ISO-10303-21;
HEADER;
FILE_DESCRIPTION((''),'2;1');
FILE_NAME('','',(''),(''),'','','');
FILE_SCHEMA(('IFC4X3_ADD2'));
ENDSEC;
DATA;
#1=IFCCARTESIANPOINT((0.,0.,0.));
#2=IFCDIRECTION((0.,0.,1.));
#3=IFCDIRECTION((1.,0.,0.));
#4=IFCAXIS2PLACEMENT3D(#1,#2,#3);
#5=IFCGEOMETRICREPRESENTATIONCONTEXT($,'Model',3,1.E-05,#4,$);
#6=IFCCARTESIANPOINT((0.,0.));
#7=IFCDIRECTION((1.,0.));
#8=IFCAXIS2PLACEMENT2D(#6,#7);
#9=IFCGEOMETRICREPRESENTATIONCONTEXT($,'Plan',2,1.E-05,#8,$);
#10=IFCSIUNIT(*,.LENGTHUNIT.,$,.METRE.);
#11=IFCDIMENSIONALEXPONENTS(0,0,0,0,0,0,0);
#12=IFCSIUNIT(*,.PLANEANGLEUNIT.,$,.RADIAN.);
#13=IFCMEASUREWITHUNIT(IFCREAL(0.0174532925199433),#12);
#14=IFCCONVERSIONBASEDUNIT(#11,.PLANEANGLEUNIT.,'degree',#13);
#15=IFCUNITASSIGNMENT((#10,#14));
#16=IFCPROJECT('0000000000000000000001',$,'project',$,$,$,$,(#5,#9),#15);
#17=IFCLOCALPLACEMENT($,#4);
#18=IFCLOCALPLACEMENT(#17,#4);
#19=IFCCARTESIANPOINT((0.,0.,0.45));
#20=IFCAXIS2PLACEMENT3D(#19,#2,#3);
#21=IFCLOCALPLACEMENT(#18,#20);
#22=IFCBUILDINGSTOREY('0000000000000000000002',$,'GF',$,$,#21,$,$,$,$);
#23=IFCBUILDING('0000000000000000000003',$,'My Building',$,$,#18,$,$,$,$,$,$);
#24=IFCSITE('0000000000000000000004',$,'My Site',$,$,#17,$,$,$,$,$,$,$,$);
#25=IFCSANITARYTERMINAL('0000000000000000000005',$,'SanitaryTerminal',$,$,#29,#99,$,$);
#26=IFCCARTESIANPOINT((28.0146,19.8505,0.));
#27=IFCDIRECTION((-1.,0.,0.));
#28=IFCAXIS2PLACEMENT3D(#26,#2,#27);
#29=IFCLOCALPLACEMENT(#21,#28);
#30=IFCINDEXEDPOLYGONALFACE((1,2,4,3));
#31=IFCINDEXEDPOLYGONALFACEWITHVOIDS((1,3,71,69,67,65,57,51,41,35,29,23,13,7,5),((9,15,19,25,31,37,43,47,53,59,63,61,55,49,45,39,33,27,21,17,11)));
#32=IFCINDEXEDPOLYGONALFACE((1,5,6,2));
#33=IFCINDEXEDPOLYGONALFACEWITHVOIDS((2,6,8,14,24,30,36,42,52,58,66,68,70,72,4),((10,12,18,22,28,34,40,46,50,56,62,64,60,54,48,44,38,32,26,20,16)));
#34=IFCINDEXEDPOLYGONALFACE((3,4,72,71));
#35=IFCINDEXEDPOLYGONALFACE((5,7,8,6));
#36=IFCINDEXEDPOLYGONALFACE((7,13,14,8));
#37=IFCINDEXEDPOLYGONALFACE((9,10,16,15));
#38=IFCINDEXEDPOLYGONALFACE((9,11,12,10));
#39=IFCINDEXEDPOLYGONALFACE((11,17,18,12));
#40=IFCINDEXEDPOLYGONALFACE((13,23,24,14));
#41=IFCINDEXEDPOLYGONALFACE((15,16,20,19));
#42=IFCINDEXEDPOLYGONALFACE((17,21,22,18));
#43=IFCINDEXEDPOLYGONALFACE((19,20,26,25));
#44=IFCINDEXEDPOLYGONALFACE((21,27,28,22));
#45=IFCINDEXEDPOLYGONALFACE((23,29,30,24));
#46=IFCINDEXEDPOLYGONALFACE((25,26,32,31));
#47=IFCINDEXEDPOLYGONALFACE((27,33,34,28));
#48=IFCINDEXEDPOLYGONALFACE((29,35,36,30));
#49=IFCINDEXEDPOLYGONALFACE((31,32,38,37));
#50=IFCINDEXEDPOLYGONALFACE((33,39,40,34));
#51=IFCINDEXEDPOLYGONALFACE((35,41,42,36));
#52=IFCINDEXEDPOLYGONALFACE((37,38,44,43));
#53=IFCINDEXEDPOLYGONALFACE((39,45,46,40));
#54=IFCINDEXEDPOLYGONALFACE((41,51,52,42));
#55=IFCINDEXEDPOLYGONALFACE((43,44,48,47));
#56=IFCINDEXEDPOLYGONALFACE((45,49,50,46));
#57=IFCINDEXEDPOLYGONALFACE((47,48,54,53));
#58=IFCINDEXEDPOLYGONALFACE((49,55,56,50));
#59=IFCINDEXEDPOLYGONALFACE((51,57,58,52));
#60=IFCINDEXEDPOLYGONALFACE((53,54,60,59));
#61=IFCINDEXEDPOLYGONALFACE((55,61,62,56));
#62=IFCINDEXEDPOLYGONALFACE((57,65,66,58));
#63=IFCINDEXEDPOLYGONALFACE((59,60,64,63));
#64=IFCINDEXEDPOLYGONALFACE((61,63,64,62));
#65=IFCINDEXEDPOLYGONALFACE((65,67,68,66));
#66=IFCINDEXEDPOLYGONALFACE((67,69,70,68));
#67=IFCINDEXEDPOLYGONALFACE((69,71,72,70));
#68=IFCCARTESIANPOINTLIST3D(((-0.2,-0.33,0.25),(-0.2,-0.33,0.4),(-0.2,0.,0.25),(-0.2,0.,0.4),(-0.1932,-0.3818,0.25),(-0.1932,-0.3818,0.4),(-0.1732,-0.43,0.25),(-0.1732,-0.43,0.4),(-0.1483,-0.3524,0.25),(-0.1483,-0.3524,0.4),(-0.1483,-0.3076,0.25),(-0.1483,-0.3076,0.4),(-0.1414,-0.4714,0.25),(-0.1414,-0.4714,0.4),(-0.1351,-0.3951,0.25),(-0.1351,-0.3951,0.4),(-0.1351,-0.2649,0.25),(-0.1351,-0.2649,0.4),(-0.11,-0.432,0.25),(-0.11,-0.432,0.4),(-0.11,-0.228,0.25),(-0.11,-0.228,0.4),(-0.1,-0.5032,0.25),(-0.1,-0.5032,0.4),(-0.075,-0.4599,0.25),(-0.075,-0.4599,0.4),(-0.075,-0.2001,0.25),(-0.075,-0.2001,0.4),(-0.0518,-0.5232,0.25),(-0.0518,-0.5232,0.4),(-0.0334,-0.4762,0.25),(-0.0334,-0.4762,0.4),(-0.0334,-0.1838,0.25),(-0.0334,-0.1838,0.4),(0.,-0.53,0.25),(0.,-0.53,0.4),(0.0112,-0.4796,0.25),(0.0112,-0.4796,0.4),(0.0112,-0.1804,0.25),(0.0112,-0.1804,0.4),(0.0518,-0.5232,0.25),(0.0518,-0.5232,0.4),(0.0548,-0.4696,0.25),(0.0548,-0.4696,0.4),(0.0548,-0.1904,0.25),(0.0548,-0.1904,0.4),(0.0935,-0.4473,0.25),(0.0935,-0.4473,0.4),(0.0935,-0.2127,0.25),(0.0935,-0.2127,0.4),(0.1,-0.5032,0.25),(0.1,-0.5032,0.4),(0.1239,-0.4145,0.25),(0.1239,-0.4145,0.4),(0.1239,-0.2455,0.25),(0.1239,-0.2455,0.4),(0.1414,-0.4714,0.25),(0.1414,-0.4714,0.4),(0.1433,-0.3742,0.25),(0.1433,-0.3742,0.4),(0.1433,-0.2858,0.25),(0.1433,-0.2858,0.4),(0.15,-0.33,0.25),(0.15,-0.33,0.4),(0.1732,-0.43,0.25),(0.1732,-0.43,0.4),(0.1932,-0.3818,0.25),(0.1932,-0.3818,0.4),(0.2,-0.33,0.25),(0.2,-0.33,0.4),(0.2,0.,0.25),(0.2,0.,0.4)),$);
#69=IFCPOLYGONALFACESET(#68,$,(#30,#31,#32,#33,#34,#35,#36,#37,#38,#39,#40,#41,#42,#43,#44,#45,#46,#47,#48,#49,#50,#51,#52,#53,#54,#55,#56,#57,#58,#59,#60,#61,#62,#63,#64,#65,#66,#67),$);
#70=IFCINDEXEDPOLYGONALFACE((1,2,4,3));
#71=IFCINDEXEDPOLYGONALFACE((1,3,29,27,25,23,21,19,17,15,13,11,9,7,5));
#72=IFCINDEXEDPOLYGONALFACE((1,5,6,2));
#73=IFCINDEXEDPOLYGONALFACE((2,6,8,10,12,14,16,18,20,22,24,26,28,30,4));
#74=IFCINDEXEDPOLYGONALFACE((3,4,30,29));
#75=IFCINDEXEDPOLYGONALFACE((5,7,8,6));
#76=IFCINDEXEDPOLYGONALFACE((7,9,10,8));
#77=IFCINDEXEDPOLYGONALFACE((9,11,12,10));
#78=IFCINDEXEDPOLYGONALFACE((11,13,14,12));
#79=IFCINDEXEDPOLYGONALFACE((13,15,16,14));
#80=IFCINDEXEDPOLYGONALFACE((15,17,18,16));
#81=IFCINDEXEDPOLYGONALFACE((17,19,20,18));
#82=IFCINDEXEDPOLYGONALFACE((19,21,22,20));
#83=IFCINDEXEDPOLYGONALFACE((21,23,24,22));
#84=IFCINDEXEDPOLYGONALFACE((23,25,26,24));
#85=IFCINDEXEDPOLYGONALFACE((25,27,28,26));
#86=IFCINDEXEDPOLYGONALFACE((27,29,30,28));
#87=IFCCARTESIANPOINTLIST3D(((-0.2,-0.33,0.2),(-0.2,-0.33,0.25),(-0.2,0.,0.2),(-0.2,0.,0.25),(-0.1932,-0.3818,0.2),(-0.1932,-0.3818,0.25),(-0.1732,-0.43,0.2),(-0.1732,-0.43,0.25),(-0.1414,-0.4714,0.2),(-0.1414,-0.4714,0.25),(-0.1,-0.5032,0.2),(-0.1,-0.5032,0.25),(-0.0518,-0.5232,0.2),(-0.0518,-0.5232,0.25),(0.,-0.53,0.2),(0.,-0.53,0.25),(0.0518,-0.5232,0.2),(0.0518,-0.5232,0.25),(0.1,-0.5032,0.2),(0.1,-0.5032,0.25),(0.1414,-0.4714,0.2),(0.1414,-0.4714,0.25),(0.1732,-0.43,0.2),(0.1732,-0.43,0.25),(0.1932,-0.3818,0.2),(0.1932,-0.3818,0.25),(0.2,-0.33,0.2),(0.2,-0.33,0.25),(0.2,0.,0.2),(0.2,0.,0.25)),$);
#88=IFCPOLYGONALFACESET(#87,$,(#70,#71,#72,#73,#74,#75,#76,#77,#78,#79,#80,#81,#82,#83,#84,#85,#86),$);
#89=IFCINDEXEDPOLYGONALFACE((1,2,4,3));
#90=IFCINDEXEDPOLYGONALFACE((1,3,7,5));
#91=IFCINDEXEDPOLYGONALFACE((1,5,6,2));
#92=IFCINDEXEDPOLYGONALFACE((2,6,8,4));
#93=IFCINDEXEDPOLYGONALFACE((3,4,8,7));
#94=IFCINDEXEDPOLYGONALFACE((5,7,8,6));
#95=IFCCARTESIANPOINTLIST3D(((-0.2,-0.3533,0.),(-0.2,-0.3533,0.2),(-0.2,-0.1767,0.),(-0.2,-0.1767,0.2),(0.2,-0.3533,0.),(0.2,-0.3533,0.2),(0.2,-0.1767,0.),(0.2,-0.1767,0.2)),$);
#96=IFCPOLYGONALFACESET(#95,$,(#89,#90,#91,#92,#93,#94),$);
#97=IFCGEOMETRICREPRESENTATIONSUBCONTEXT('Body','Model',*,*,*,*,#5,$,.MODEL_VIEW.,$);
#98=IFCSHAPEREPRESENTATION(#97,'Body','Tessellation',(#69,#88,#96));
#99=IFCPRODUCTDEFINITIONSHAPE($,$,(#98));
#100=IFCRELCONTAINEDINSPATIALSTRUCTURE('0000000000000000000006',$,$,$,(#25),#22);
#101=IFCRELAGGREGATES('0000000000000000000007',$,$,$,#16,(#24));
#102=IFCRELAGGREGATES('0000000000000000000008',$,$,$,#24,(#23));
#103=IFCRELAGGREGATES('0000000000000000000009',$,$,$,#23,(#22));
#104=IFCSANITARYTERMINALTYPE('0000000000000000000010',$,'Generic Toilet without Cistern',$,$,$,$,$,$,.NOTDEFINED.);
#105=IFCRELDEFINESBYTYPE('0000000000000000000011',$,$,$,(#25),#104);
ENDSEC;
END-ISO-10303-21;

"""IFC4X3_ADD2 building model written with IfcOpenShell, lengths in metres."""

from ifc_helpers import new_model, entity, si_unit, converted_unit, frame, frame_2d, origin_with_axes, origin_2d_with_axis, place, context, subcontext, project, spatial, line, arc, indexed_curve, circle_curve, outline, extrude, shape, source, transform, mapped, type_object, type_shapes, element, save


model = new_model("IFC4X3_ADD2")

# Units and contexts
model_context = context("Model", 3, precision=1e-05, world=origin_with_axes())
plan_context = context("Plan", 2, precision=1e-05, world=origin_2d_with_axis())
body_context_1 = subcontext(model_context, "Body", "Model", "MODEL_VIEW")
body_context_2 = subcontext(plan_context, "Body", "Plan", "PLAN_VIEW")
ifc_project = project(units=[si_unit("LENGTHUNIT", "METRE"), converted_unit("PLANEANGLEUNIT", "degree", entity("IfcReal", 0.0174532925199433), si_unit("PLANEANGLEUNIT", "RADIAN"), dimensions=[0, 0, 0, 0, 0, 0, 0])], contexts=[model_context, plan_context])

# Site, building, storey
site_placement = place(None, origin_with_axes())
site = spatial("IfcSite", under=ifc_project, at=site_placement, Name="My Site")
building_placement = place(site_placement, origin_with_axes())
building = spatial("IfcBuilding", under=site, at=building_placement, Name="My Building")
storey_placement = place(building_placement, frame((0.0, 0.0, 0.45), z_axis=(0.0, 0.0, 1.0), x_axis=(1.0, 0.0, 0.0)))
storey = spatial("IfcBuildingStorey", under=building, at=storey_placement, Name="GF")

# Sanitary terminal
sanitary_terminal_type_1 = type_object("IfcSanitaryTerminalType", Name="Generic Toilet without Cistern", PredefinedType="NOTDEFINED")
shared_shape_1 = source(origin_with_axes(), body_context_1, "Body", "SweptSolid", [
    extrude(outline(indexed_curve([(-0.2, 0.0), (0.2, 0.0), (0.2, -0.33), (0.1414, -0.4714), (0.0, -0.53), (-0.1414, -0.4714), (-0.2, -0.33)], segments=[line(1, 2), line(2, 3), arc(3, 4, 5), arc(5, 6, 7), line(7, 1)]), holes=[circle_curve(frame_2d((0.0, -0.33)), 0.15)]), frame((0.0, 0.0, 0.25), z_axis=(0.0, 0.0, 1.0), x_axis=(1.0, 0.0, 0.0)), (0.0, 0.0, 1.0), 0.15),
    extrude(outline(indexed_curve([(-0.2, 0.0), (0.2, 0.0), (0.2, -0.33), (0.1414, -0.4714), (0.0, -0.53), (-0.1414, -0.4714), (-0.2, -0.33)], segments=[line(1, 2), line(2, 3), arc(3, 4, 5), arc(5, 6, 7), line(7, 1)])), frame((0.0, 0.0, 0.2), z_axis=(0.0, 0.0, 1.0), x_axis=(1.0, 0.0, 0.0)), (0.0, 0.0, 1.0), 0.05),
    extrude(outline(indexed_curve([(-0.2, -0.1767), (0.2, -0.1767), (0.2, -0.3533), (-0.2, -0.3533)], segments=[line(1, 2, 3, 4, 1)])), origin_with_axes(), (0.0, 0.0, 1.0), 0.2),
])
shared_shape_2 = source(origin_with_axes(), body_context_2, "Body", "Annotation2D", [
    entity("IfcGeometricCurveSet", [entity("IfcIndexedPolyCurve", entity("IfcCartesianPointList2D", [[-0.1068, -0.124], [-0.0957, -0.1129], [-0.0804, -0.1088], [0.0804, -0.1088], [0.0957, -0.1129], [0.1068, -0.124], [0.1109, -0.1393], [0.1109, -0.3476], [0.1025, -0.3926], [0.0784, -0.4308], [0.0424, -0.4563], [0.0, -0.4652], [-0.0424, -0.4563], [-0.0784, -0.4308], [-0.1025, -0.3926], [-0.1109, -0.3476], [-0.1109, -0.1393]]), [entity("IfcLineIndex", [1, 2, 3, 4, 5, 6, 7, 8, 9, 10, 11, 12, 13, 14, 15, 16, 17, 1])]), entity("IfcIndexedPolyCurve", entity("IfcCartesianPointList2D", [[-0.1962, -0.2314], [-0.1848, -0.301], [-0.1764, -0.3339], [-0.1663, -0.3651], [-0.1546, -0.3944], [-0.1414, -0.4213], [-0.1269, -0.4458], [-0.1111, -0.4675], [-0.0943, -0.4862], [-0.0765, -0.5018], [-0.0581, -0.514], [-0.039, -0.5229], [-0.0196, -0.5282], [0.0, -0.53], [0.0196, -0.5282], [0.039, -0.5229], [0.0581, -0.514], [0.0765, -0.5018], [0.0943, -0.4862], [0.1111, -0.4675], [0.1269, -0.4458], [0.1414, -0.4213], [0.1546, -0.3944], [0.1663, -0.3651], [0.1764, -0.3339], [0.1848, -0.301], [0.1962, -0.2314], [0.2, -0.159], [0.1872, 0.0], [-0.1872, 0.0], [-0.2, -0.159]]), [entity("IfcLineIndex", [1, 2, 3, 4, 5, 6, 7, 8, 9, 10, 11, 12, 13, 14, 15, 16, 17, 18, 19, 20, 21, 22, 23, 24, 25, 26, 27, 28, 29, 30, 31, 1])])]),
])
type_shapes(sanitary_terminal_type_1, [shared_shape_1, shared_shape_2])
for number, where, z_axis, x_axis, name in (
    (1, (28.0146, 19.8505, 0.0), (0.0, 0.0, 1.0), (-1.0, 0.0, 0.0), "SanitaryTerminal"),
):
    element("IfcSanitaryTerminal", number, at=place(storey_placement, frame(where, z_axis=z_axis, x_axis=x_axis)), inside=storey, type_object=sanitary_terminal_type_1, Name=name, shapes=[
        shape(body_context_1, "Body", "MappedRepresentation", [mapped(shared_shape_1, transform((0.0, 0.0, 0.0), x_axis=(1.0, 0.0, 0.0), y_axis=(0.0, 1.0, 0.0), z_axis=(0.0, 0.0, 1.0), scale=1.0))]),
        shape(body_context_2, "Body", "MappedRepresentation", [mapped(shared_shape_2, transform((0.0, 0.0, 0.0), x_axis=(1.0, 0.0, 0.0), y_axis=(0.0, 1.0, 0.0), z_axis=(0.0, 0.0, 1.0), scale=1.0))]),
    ])

save(model, "model.ifc")
